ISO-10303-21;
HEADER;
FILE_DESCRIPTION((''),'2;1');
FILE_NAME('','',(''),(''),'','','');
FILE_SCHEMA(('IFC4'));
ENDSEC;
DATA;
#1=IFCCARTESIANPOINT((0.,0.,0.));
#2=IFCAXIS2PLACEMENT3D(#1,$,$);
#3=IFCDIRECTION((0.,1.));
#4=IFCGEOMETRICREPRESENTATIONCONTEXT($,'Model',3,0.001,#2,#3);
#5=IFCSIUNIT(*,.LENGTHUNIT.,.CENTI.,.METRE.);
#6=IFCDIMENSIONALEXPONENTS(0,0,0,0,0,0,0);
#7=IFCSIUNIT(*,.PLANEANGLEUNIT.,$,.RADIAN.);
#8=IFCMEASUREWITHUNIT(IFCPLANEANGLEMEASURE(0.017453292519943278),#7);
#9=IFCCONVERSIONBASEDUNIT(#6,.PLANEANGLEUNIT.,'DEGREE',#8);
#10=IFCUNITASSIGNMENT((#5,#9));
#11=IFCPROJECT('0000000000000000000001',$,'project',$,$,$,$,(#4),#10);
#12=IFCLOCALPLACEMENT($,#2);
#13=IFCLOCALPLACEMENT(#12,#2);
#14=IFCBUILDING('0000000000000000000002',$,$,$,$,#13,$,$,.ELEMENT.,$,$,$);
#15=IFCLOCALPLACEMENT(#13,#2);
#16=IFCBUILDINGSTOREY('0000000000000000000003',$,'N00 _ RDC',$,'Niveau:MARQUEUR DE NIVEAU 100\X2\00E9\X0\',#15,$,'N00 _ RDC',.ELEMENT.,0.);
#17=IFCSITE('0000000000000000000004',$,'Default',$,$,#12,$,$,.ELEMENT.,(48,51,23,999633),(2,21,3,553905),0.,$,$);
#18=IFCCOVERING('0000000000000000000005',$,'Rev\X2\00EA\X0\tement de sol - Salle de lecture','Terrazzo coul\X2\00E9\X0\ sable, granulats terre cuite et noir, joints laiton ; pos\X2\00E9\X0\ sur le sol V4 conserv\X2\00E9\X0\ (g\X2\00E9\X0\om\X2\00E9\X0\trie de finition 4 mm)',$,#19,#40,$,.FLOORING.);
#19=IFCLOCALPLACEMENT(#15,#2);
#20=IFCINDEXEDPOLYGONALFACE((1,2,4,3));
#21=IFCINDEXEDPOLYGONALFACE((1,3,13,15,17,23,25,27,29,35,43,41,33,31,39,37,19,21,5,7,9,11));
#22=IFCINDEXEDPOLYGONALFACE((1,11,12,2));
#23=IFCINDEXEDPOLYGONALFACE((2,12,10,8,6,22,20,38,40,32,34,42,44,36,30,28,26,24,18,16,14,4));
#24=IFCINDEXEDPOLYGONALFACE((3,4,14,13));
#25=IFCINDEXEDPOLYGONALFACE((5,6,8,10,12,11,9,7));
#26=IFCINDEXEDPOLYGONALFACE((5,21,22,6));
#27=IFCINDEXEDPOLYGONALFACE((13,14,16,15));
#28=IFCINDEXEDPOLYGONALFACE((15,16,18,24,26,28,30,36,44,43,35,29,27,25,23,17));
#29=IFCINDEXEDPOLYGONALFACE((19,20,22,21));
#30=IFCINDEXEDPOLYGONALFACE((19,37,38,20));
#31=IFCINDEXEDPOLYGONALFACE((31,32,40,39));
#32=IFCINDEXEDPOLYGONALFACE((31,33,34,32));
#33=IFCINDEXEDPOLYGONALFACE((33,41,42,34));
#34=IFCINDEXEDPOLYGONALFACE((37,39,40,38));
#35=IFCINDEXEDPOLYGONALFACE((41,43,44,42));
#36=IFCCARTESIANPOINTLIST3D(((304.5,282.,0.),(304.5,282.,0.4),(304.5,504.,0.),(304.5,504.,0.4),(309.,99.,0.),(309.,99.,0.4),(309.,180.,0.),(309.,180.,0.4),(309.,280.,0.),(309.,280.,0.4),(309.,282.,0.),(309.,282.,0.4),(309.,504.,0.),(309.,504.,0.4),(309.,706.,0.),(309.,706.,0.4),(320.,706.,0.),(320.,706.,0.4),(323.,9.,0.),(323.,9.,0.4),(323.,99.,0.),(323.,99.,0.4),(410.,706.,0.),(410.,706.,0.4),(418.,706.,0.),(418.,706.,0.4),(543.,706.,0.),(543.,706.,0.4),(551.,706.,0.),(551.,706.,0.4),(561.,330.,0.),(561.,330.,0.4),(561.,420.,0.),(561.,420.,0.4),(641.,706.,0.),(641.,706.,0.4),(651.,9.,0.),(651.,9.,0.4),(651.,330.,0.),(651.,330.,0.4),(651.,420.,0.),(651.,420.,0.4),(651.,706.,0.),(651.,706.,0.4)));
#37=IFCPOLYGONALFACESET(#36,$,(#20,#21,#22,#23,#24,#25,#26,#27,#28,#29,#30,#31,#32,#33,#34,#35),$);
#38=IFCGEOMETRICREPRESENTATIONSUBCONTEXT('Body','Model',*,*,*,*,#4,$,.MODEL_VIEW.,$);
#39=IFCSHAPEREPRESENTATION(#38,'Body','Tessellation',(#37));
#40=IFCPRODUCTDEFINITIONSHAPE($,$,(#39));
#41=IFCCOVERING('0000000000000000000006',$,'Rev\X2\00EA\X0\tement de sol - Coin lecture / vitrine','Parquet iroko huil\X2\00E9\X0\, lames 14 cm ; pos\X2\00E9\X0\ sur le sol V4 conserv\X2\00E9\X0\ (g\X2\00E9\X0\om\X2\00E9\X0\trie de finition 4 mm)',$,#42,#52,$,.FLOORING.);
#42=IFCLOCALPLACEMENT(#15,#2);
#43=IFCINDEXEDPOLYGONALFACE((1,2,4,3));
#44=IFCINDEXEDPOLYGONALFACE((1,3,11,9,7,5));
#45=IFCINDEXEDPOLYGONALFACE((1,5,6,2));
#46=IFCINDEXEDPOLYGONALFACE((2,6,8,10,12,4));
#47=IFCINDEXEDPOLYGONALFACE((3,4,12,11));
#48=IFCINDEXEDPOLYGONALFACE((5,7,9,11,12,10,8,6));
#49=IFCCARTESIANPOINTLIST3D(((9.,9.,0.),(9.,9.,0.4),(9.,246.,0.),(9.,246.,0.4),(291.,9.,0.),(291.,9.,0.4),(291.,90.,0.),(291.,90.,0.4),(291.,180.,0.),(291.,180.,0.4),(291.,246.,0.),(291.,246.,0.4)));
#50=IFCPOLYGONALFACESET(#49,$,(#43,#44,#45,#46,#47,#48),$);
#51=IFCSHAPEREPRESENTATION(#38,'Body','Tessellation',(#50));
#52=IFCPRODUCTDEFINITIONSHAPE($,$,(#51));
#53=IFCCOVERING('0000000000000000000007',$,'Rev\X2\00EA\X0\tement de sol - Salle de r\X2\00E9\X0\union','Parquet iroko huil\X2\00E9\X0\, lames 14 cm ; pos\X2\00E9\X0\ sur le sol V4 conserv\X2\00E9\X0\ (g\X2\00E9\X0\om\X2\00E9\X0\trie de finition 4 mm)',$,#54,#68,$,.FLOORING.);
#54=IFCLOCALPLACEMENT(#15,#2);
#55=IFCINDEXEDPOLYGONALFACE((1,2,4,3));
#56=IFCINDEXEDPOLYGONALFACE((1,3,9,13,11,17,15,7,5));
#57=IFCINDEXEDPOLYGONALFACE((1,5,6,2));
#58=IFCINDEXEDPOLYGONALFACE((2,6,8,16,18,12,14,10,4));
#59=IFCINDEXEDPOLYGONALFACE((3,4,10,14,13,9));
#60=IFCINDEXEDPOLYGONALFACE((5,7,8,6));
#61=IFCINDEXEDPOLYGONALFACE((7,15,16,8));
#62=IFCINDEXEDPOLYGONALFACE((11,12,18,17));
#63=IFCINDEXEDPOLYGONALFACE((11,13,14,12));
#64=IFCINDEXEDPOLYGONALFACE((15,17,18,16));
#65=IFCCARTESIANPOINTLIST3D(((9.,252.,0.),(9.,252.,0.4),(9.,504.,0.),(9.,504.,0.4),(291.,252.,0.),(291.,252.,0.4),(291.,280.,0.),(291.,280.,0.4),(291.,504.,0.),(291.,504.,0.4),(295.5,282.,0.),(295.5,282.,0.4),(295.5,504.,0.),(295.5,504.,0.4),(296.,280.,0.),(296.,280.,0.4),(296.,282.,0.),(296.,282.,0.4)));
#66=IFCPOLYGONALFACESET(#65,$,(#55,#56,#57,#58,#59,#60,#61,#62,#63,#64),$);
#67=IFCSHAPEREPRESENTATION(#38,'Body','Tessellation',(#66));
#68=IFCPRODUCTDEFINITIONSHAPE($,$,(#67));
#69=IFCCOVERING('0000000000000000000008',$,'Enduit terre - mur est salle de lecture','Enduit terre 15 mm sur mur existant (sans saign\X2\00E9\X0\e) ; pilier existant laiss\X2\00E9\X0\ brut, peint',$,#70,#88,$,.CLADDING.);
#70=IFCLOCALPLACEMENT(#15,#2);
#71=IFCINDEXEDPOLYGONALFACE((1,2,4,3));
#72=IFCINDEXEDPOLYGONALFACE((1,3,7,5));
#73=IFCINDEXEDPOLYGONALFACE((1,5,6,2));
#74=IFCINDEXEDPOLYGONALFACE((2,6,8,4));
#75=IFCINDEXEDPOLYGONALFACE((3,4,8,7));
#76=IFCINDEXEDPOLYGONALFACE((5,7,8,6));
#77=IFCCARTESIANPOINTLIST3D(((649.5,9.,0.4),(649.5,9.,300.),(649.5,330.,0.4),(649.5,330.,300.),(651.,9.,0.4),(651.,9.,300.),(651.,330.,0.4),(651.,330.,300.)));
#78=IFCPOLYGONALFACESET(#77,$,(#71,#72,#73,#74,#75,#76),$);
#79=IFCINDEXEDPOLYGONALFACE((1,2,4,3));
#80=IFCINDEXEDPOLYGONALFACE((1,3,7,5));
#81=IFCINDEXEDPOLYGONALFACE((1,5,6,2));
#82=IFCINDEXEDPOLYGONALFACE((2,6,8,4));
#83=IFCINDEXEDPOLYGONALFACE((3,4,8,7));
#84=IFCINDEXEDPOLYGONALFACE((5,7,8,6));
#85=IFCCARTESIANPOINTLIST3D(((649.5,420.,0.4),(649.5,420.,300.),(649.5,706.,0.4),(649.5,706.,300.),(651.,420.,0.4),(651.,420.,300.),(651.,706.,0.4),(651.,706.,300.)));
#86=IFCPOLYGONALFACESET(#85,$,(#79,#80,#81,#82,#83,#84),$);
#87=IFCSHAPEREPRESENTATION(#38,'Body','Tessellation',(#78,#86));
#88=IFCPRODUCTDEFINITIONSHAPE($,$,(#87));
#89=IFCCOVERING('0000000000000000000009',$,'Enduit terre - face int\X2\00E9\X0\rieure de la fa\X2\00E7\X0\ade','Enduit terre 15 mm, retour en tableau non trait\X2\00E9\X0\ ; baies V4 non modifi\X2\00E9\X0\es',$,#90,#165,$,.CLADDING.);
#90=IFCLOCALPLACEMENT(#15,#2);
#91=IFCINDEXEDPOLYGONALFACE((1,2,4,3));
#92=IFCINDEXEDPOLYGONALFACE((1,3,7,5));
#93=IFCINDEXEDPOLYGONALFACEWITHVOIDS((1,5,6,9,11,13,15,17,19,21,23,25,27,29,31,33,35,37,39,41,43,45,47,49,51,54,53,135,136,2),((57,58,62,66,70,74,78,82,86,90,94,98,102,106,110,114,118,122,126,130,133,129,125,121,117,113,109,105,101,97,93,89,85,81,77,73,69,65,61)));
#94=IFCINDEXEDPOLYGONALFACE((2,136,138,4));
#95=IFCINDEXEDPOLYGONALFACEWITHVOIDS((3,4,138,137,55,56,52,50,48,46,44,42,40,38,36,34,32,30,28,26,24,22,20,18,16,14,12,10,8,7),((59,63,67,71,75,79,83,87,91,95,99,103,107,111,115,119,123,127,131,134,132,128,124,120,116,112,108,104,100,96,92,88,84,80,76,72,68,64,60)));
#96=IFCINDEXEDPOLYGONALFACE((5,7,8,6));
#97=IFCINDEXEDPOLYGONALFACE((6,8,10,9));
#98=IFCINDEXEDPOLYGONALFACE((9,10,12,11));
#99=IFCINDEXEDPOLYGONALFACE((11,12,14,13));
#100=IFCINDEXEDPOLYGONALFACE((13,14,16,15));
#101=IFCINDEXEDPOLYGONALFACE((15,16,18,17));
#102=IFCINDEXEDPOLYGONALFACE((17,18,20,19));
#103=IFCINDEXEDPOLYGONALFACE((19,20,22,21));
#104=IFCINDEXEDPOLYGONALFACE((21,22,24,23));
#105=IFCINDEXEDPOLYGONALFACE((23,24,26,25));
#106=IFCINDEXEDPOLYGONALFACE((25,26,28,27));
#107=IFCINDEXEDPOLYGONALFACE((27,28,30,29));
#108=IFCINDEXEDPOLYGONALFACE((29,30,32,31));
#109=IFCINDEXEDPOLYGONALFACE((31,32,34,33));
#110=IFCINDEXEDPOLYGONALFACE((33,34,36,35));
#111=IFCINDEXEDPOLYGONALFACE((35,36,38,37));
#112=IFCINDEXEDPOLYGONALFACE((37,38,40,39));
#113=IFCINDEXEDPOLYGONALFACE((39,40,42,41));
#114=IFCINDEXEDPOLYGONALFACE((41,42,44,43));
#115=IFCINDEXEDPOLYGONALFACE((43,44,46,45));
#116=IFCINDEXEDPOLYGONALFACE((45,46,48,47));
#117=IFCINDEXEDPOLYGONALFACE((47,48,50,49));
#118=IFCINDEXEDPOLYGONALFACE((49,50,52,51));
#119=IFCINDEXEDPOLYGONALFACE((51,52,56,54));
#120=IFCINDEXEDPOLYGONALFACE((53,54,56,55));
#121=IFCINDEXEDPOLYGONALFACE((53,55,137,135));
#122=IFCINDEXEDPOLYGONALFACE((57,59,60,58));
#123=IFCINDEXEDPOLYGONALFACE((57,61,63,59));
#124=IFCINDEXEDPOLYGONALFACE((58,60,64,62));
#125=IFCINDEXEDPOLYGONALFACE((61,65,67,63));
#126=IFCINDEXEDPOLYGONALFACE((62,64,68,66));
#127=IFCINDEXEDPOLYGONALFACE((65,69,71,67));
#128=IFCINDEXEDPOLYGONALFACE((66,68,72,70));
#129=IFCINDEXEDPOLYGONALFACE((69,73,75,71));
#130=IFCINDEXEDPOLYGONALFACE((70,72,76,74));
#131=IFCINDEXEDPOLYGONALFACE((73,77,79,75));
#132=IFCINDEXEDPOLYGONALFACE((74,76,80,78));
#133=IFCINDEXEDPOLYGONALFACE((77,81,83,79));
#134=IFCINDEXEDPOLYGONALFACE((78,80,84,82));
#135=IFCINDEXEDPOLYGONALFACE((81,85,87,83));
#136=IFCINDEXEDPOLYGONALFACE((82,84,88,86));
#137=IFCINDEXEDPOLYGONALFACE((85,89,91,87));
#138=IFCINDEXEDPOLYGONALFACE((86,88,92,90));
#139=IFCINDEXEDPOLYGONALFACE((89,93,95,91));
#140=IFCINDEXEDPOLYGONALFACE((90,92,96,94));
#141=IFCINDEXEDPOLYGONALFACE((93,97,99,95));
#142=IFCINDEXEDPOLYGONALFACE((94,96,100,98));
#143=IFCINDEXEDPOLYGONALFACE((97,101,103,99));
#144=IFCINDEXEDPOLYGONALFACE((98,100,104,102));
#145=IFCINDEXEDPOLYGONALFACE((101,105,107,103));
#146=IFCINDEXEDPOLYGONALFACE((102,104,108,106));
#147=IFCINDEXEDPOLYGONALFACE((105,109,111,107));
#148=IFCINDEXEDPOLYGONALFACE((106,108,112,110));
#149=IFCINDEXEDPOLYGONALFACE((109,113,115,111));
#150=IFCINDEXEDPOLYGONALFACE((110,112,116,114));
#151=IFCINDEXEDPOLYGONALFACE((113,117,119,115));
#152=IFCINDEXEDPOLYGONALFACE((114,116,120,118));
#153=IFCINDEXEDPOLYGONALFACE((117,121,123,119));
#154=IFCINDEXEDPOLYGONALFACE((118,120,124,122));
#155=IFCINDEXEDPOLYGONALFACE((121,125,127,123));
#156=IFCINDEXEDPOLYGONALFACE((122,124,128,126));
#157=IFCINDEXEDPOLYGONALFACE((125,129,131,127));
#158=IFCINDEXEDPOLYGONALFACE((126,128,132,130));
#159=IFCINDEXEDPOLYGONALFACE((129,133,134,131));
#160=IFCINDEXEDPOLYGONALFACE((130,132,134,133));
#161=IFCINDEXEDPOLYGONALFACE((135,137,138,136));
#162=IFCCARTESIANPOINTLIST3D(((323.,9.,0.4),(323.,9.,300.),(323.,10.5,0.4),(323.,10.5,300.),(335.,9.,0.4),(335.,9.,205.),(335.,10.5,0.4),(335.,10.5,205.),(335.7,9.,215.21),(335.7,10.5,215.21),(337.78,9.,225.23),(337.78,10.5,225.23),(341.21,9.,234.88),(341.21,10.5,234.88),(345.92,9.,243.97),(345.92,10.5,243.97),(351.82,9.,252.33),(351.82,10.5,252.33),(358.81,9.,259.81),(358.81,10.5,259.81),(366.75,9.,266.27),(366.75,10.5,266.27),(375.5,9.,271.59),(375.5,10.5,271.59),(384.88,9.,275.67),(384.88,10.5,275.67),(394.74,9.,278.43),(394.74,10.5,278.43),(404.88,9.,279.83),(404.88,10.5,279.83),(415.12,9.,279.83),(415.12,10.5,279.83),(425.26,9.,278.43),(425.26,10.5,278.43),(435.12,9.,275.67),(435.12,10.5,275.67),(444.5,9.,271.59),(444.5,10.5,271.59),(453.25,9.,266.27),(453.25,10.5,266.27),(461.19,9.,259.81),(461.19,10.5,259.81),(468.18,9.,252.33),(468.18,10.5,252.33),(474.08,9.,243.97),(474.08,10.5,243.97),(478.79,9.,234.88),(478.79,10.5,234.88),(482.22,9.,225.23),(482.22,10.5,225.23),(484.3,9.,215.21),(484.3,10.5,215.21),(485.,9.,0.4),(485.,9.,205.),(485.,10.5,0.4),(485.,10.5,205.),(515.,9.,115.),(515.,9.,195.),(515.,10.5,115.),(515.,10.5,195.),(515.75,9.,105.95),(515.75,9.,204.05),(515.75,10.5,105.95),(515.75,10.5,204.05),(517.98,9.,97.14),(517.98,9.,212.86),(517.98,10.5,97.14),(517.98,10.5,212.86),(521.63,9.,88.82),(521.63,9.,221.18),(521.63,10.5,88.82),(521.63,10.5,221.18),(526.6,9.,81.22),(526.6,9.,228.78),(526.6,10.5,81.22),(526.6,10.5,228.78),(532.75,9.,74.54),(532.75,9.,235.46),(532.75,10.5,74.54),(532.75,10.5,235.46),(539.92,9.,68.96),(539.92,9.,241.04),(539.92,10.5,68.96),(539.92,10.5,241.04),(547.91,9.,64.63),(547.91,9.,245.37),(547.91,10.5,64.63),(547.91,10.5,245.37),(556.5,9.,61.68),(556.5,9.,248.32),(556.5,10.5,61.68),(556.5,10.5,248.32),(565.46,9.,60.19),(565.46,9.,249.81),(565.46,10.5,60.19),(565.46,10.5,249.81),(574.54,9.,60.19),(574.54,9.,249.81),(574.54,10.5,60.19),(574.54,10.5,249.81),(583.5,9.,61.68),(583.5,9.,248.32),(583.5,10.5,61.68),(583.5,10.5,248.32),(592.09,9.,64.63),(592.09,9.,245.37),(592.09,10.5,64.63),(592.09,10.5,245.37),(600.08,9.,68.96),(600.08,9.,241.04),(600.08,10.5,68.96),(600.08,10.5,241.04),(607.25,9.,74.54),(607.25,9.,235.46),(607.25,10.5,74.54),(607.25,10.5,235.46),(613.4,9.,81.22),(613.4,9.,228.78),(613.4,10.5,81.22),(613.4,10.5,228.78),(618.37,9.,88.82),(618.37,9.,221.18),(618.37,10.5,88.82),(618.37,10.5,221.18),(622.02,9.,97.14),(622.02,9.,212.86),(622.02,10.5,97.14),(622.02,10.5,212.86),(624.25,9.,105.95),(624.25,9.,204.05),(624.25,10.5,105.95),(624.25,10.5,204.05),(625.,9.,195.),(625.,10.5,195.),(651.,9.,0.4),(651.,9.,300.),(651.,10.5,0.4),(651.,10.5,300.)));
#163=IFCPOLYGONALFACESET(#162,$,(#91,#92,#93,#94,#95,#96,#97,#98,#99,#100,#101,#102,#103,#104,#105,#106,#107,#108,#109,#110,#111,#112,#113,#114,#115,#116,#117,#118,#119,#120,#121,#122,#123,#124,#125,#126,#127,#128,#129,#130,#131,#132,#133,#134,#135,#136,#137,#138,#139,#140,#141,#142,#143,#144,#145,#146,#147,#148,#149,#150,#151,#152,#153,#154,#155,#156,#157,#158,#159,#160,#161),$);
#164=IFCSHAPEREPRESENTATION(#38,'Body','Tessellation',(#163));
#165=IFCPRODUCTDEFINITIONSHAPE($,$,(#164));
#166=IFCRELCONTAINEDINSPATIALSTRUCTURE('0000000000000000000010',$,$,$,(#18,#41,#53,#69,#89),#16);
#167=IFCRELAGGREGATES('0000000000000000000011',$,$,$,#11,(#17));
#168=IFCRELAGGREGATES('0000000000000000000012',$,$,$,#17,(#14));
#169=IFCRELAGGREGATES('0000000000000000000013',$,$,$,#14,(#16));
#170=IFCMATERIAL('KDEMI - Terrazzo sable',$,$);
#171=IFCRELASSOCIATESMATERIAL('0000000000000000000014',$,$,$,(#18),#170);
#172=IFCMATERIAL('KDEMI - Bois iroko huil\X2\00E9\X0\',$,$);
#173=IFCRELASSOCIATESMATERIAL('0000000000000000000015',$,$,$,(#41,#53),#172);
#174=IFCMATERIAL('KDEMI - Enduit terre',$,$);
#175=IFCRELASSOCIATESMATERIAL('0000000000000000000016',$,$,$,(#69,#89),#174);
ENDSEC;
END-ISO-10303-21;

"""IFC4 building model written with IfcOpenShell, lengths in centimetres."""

from ifc_helpers import new_model, entity, si_unit, converted_unit, direction, frame, frame_2d, origin, origin_with_axes, place, context, subcontext, project, spatial, polyline, rectangle, outline, extrude, material, element, save


model = new_model("IFC4")

# Units and contexts
model_context = context("Model", 3, precision=0.001, world=origin(), true_north=direction((0.0, 1.0)))
body_context = subcontext(model_context, "Body", "Model", "MODEL_VIEW")
ifc_project = project(units=[si_unit("LENGTHUNIT", "METRE", prefix="CENTI"), converted_unit("PLANEANGLEUNIT", "DEGREE", entity("IfcPlaneAngleMeasure", 0.017453292519943278), si_unit("PLANEANGLEUNIT", "RADIAN"), dimensions=[0, 0, 0, 0, 0, 0, 0])], contexts=[model_context])

# Site, building, storey
site_placement = place(None, origin())
site = spatial("IfcSite", under=ifc_project, at=site_placement, Name="Default", CompositionType="ELEMENT", RefLatitude=(48, 51, 23, 999633), RefLongitude=(2, 21, 3, 553905), RefElevation=0.0)
building_placement = place(site_placement, origin())
building = spatial("IfcBuilding", under=site, at=building_placement, CompositionType="ELEMENT")
storey_placement = place(building_placement, origin())
storey = spatial("IfcBuildingStorey", under=building, at=storey_placement, Name="N00 _ RDC", ObjectType="Niveau:MARQUEUR DE NIVEAU 100é", LongName="N00 _ RDC", CompositionType="ELEMENT", Elevation=0.0)

# Coverings
ifc_material_1 = material(Name="KDEMI - Terrazzo sable")
covering_1_placement = place(storey_placement, origin_with_axes())
element("IfcCovering", 1, at=covering_1_placement, inside=storey, material=ifc_material_1, Name="Revêtement de sol - Salle de lecture", Description="Terrazzo coulé sable, granulats terre cuite et noir, joints laiton ; posé sur le sol V4 conservé (géométrie de finition 4 mm)", PredefinedType="FLOORING", context=body_context, shape_type="SweptSolid", body=[
    extrude(outline(polyline([(418.0, 706.0), (543.0, 706.0), (551.0, 706.0), (641.0, 706.0), (651.0, 706.0), (651.0, 420.0), (561.0, 420.0), (561.0, 330.0), (651.0, 330.0), (651.0, 9.0), (651.0, 9.0), (651.0, 9.0), (323.0, 9.0), (323.0, 99.0), (309.0, 99.0), (309.0, 180.0), (309.0, 180.0), (309.0, 280.0), (309.0, 280.0), (309.0, 282.0), (304.0, 282.0), (304.0, 282.0), (304.5, 282.0), (304.5, 504.0), (309.0, 504.0), (309.0, 504.0), (309.0, 706.0), (320.0, 706.0), (410.0, 706.0), (418.0, 706.0)])), origin(), (0.0, 0.0, 1.0), 0.4),
])
ifc_material_2 = material(Name="KDEMI - Bois iroko huilé")
covering_2_placement = place(storey_placement, origin_with_axes())
element("IfcCovering", 2, at=covering_2_placement, inside=storey, material=ifc_material_2, Name="Revêtement de sol - Coin lecture / vitrine", Description="Parquet iroko huilé, lames 14 cm ; posé sur le sol V4 conservé (géométrie de finition 4 mm)", PredefinedType="FLOORING", context=body_context, shape_type="SweptSolid", body=[
    extrude(outline(polyline([(291.0, 90.0), (291.0, 90.0), (291.0, 9.0), (9.0, 9.0), (9.0, 246.0), (291.0, 246.0), (291.0, 180.0), (291.0, 180.0), (291.0, 90.0)])), origin(), (0.0, 0.0, 1.0), 0.4),
])
covering_3_placement = place(storey_placement, origin_with_axes())
element("IfcCovering", 3, at=covering_3_placement, inside=storey, material=ifc_material_2, Name="Revêtement de sol - Salle de réunion", Description="Parquet iroko huilé, lames 14 cm ; posé sur le sol V4 conservé (géométrie de finition 4 mm)", PredefinedType="FLOORING", context=body_context, shape_type="SweptSolid", body=[
    extrude(outline(polyline([(296.0, 280.0), (291.0, 280.0), (291.0, 252.0), (9.0, 252.0), (9.0, 504.0), (291.0, 504.0), (295.5, 504.0), (295.5, 282.0), (296.0, 282.0), (296.0, 280.0)])), origin(), (0.0, 0.0, 1.0), 0.4),
])
ifc_material_3 = material(Name="KDEMI - Enduit terre")
covering_4_placement = place(storey_placement, origin_with_axes())
element("IfcCovering", 4, at=covering_4_placement, inside=storey, material=ifc_material_3, Name="Enduit terre - mur est salle de lecture", Description="Enduit terre 15 mm sur mur existant (sans saignée) ; pilier existant laissé brut, peint", PredefinedType="CLADDING", context=body_context, shape_type="SweptSolid", body=[
    extrude(rectangle(XDim=1.5, YDim=321.0, at=frame_2d((650.25, 169.5))), frame((0.0, 0.0, 0.4)), (0.0, 0.0, 1.0), 299.6),
    extrude(rectangle(XDim=1.5, YDim=286.0, at=frame_2d((650.25, 563.0))), frame((0.0, 0.0, 0.4)), (0.0, 0.0, 1.0), 299.6),
])
covering_5_placement = place(storey_placement, origin_with_axes())
element("IfcCovering", 5, at=covering_5_placement, inside=storey, material=ifc_material_3, Name="Enduit terre - face intérieure de la façade", Description="Enduit terre 15 mm, retour en tableau non traité ; baies V4 non modifiées", PredefinedType="CLADDING", context=body_context, shape_type="SweptSolid", body=[
    extrude(outline(polyline([(323.0, 300.0), (651.0, 300.0), (651.0, 0.4), (485.0, 0.4), (485.0, 205.0), (484.3, 215.21), (482.22, 225.23), (478.79, 234.88), (474.08, 243.97), (468.18, 252.33), (461.19, 259.81), (453.25, 266.27), (444.5, 271.59), (435.12, 275.67), (425.26, 278.43), (415.12, 279.83), (404.88, 279.83), (394.74, 278.43), (384.88, 275.67), (375.5, 271.59), (366.75, 266.27), (358.81, 259.81), (351.82, 252.33), (345.92, 243.97), (341.21, 234.88), (337.78, 225.23), (335.7, 215.21), (335.0, 205.0), (335.0, 0.4), (323.0, 0.4), (323.0, 300.0)]), holes=[polyline([(624.25, 204.05), (622.02, 212.86), (618.37, 221.18), (613.4, 228.78), (607.25, 235.46), (600.08, 241.04), (592.09, 245.37), (583.5, 248.32), (574.54, 249.81), (565.46, 249.81), (556.5, 248.32), (547.91, 245.37), (539.92, 241.04), (532.75, 235.46), (526.6, 228.78), (521.63, 221.18), (517.98, 212.86), (515.75, 204.05), (515.0, 195.0), (515.0, 115.0), (515.75, 105.95), (517.98, 97.14), (521.63, 88.82), (526.6, 81.22), (532.75, 74.54), (539.92, 68.96), (547.91, 64.63), (556.5, 61.68), (565.46, 60.19), (574.54, 60.19), (583.5, 61.68), (592.09, 64.63), (600.08, 68.96), (607.25, 74.54), (613.4, 81.22), (618.37, 88.82), (622.02, 97.14), (624.25, 105.95), (625.0, 195.0), (624.25, 204.05)])]), frame((0.0, 10.5, 0.0), z_axis=(0.0, -1.0, 0.0), x_axis=(1.0, 0.0, 0.0)), (0.0, 0.0, 1.0), 1.5),
])

save(model, "model.ifc")
